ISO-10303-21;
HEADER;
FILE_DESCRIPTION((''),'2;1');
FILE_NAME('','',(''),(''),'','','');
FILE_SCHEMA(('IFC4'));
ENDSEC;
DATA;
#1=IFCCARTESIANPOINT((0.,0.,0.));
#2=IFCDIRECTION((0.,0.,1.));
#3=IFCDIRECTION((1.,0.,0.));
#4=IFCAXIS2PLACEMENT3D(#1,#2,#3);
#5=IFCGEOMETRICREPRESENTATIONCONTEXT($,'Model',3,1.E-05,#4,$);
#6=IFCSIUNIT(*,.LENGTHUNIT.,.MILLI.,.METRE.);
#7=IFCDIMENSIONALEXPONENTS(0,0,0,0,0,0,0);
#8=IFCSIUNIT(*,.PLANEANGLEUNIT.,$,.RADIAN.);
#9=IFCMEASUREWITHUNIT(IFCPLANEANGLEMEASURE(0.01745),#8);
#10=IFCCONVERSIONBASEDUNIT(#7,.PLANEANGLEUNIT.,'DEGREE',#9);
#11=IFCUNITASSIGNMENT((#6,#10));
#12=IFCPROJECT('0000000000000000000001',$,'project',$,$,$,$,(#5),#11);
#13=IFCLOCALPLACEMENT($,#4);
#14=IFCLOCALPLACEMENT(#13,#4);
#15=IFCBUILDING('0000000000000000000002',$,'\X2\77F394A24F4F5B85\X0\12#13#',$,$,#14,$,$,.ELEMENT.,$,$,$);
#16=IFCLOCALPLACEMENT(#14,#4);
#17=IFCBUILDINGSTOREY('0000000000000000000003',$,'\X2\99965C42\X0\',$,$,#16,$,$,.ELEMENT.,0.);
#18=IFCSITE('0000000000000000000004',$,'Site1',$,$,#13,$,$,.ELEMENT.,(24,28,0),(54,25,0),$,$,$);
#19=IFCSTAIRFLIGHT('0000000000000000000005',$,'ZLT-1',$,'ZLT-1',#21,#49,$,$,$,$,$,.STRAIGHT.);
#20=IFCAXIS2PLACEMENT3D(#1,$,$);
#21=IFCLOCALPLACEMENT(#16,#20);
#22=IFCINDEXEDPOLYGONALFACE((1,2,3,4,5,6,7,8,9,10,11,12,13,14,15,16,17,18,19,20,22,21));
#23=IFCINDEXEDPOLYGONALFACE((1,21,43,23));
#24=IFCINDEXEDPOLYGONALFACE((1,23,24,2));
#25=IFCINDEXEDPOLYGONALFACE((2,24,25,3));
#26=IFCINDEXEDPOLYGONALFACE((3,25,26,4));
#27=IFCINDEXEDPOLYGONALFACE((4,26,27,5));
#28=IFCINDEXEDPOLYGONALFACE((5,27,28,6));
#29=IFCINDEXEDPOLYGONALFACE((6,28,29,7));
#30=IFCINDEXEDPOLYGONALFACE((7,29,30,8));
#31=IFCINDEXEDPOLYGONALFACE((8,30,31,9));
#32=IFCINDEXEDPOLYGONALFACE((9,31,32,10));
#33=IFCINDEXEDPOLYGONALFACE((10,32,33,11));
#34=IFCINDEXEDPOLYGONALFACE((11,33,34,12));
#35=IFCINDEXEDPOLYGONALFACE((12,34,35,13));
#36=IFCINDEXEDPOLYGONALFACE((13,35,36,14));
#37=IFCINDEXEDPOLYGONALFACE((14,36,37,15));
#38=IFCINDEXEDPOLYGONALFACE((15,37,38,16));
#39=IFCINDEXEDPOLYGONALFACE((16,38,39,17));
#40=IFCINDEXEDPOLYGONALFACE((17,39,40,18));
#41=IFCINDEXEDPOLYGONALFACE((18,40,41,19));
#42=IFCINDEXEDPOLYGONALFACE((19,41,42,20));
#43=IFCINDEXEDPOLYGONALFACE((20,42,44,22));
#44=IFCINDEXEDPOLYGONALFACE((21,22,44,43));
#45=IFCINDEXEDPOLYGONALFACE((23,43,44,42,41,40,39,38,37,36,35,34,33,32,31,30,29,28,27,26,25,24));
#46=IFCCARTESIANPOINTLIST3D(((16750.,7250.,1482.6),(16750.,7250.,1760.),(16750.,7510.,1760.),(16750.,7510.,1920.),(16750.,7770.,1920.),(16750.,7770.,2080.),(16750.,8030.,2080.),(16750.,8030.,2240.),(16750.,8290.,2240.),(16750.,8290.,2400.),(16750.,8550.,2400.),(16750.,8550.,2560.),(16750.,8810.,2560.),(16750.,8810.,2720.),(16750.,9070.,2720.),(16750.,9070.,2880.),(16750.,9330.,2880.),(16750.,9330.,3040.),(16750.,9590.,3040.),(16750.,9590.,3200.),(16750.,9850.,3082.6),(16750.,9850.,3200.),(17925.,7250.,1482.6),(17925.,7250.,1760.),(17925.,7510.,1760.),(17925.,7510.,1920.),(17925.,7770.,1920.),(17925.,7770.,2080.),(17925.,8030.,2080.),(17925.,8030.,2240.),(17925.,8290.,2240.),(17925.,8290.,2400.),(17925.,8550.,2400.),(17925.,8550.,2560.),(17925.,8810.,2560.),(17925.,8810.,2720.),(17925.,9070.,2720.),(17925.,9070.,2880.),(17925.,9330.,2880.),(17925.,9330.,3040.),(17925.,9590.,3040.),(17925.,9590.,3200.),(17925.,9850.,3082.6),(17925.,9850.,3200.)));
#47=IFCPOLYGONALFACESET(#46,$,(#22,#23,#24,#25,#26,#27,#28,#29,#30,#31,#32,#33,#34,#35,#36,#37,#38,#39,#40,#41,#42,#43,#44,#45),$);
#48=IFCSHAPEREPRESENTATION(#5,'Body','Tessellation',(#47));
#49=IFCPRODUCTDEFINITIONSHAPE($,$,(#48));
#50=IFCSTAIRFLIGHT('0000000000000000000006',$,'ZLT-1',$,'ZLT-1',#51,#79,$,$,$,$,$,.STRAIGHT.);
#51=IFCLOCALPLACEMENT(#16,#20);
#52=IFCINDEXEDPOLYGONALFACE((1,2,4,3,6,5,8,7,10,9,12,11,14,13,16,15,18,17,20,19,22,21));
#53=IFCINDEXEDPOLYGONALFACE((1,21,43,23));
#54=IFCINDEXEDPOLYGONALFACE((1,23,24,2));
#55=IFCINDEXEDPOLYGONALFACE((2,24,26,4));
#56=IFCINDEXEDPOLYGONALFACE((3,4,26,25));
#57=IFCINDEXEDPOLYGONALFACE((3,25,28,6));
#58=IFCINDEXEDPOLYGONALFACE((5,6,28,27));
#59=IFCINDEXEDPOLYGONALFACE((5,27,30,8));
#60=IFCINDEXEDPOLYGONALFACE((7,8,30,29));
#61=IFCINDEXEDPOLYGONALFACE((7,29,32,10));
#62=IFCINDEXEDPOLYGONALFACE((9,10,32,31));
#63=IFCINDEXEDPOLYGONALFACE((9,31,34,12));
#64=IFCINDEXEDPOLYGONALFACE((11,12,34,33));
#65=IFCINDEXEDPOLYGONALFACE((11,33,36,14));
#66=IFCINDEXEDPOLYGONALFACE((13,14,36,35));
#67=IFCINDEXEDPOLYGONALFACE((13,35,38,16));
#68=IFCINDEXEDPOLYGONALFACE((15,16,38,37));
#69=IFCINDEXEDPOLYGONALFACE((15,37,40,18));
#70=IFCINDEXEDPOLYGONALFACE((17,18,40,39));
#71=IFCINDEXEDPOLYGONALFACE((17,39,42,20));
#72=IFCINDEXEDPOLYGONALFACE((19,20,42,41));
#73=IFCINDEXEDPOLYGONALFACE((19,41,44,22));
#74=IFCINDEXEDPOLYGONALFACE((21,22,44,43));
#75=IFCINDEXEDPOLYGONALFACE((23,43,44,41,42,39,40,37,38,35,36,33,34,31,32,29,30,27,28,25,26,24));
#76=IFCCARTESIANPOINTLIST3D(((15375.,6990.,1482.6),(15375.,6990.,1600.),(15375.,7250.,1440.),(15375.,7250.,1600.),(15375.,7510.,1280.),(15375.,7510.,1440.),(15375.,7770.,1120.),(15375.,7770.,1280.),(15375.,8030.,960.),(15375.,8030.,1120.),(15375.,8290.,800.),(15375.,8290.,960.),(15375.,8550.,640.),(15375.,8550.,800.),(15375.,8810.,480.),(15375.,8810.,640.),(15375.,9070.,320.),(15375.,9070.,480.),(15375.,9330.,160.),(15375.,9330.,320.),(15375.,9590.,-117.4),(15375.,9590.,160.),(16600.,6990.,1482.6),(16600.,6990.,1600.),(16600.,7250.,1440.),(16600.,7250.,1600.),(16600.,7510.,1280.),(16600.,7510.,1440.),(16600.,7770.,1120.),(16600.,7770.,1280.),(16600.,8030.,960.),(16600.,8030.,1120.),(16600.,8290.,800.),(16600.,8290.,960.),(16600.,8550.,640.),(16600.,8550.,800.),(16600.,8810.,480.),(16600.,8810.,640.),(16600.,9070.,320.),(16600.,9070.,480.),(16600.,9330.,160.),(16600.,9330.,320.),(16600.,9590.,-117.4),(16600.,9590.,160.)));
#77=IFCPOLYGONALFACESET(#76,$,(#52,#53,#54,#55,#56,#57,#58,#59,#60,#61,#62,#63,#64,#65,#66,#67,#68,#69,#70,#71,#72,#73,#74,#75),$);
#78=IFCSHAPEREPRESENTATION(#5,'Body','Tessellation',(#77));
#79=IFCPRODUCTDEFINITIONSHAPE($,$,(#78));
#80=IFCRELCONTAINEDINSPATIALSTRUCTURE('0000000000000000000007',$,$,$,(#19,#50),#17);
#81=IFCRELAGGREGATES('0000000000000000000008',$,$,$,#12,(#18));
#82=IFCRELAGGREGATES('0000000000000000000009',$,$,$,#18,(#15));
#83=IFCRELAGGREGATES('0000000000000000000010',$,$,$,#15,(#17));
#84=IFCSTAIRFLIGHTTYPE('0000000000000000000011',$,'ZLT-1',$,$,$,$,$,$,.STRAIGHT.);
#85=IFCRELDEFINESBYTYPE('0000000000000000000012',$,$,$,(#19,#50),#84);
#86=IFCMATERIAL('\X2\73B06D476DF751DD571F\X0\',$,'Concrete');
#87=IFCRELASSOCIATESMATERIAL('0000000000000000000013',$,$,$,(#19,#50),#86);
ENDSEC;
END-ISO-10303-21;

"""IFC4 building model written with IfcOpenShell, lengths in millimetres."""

from ifc_helpers import new_model, entity, si_unit, converted_unit, frame, origin_with_axes, place, context, project, spatial, polyline, outline, extrude, material, type_object, element, save


model = new_model("IFC4")

# Units and contexts
model_context = context("Model", 3, precision=1e-05, world=origin_with_axes())
ifc_project = project(units=[si_unit("LENGTHUNIT", "METRE", prefix="MILLI"), converted_unit("PLANEANGLEUNIT", "DEGREE", entity("IfcPlaneAngleMeasure", 0.01745), si_unit("PLANEANGLEUNIT", "RADIAN"), dimensions=[0, 0, 0, 0, 0, 0, 0])], contexts=[model_context])

# Site, building, storey
site_placement = place(None, origin_with_axes())
site = spatial("IfcSite", under=ifc_project, at=site_placement, Name="Site1", CompositionType="ELEMENT", RefLatitude=(24, 28, 0), RefLongitude=(54, 25, 0))
building_placement = place(site_placement, origin_with_axes())
building = spatial("IfcBuilding", under=site, at=building_placement, Name="石钢住宅12#13#", CompositionType="ELEMENT")
storey_placement = place(building_placement, origin_with_axes())
storey = spatial("IfcBuildingStorey", under=building, at=storey_placement, Name="首层", CompositionType="ELEMENT", Elevation=0.0)

# Stair flights
ifc_material_1 = material(Name="现浇混凝土", Category="Concrete")
stair_flight_type = type_object("IfcStairFlightType", Name="ZLT-1", PredefinedType="STRAIGHT")
stair_flight_1_placement = place(storey_placement, origin_with_axes())
element("IfcStairFlight", 1, at=stair_flight_1_placement, inside=storey, type_object=stair_flight_type, material=ifc_material_1, Name="ZLT-1", ObjectType="ZLT-1", PredefinedType="STRAIGHT", context=model_context, shape_type="SweptSolid", body=[
    extrude(outline(polyline([(0.0, -117.4), (2600.0, 1482.6), (2600.0, 1600.0), (2340.0, 1600.0), (2340.0, 1440.0), (2080.0, 1440.0), (2080.0, 1280.0), (1820.0, 1280.0), (1820.0, 1120.0), (1560.0, 1120.0), (1560.0, 960.0), (1300.0, 960.0), (1300.0, 800.0), (1040.0, 800.0), (1040.0, 640.0), (780.0, 640.0), (780.0, 480.0), (520.0, 480.0), (520.0, 320.0), (260.0, 320.0), (260.0, 160.0), (0.0, 160.0), (0.0, -117.4)])), frame((16750.0, 7250.0, 1600.0), z_axis=(1.0, 0.0, 0.0), x_axis=(0.0, 1.0, 0.0)), (0.0, 0.0, 1.0), 1175.0),
])
stair_flight_2_placement = place(storey_placement, origin_with_axes())
element("IfcStairFlight", 2, at=stair_flight_2_placement, inside=storey, type_object=stair_flight_type, material=ifc_material_1, Name="ZLT-1", ObjectType="ZLT-1", PredefinedType="STRAIGHT", context=model_context, shape_type="SweptSolid", body=[
    extrude(outline(polyline([(0.0, -117.4), (2600.0, 1482.6), (2600.0, 1600.0), (2340.0, 1600.0), (2340.0, 1440.0), (2080.0, 1440.0), (2080.0, 1280.0), (1820.0, 1280.0), (1820.0, 1120.0), (1560.0, 1120.0), (1560.0, 960.0), (1300.0, 960.0), (1300.0, 800.0), (1040.0, 800.0), (1040.0, 640.0), (780.0, 640.0), (780.0, 480.0), (520.0, 480.0), (520.0, 320.0), (260.0, 320.0), (260.0, 160.0), (0.0, 160.0), (0.0, -117.4)])), frame((16600.0, 9590.0, 0.0), z_axis=(-1.0, 0.0, 0.0), x_axis=(0.0, -1.0, 0.0)), (0.0, 0.0, 1.0), 1225.0),
])

save(model, "model.ifc")
